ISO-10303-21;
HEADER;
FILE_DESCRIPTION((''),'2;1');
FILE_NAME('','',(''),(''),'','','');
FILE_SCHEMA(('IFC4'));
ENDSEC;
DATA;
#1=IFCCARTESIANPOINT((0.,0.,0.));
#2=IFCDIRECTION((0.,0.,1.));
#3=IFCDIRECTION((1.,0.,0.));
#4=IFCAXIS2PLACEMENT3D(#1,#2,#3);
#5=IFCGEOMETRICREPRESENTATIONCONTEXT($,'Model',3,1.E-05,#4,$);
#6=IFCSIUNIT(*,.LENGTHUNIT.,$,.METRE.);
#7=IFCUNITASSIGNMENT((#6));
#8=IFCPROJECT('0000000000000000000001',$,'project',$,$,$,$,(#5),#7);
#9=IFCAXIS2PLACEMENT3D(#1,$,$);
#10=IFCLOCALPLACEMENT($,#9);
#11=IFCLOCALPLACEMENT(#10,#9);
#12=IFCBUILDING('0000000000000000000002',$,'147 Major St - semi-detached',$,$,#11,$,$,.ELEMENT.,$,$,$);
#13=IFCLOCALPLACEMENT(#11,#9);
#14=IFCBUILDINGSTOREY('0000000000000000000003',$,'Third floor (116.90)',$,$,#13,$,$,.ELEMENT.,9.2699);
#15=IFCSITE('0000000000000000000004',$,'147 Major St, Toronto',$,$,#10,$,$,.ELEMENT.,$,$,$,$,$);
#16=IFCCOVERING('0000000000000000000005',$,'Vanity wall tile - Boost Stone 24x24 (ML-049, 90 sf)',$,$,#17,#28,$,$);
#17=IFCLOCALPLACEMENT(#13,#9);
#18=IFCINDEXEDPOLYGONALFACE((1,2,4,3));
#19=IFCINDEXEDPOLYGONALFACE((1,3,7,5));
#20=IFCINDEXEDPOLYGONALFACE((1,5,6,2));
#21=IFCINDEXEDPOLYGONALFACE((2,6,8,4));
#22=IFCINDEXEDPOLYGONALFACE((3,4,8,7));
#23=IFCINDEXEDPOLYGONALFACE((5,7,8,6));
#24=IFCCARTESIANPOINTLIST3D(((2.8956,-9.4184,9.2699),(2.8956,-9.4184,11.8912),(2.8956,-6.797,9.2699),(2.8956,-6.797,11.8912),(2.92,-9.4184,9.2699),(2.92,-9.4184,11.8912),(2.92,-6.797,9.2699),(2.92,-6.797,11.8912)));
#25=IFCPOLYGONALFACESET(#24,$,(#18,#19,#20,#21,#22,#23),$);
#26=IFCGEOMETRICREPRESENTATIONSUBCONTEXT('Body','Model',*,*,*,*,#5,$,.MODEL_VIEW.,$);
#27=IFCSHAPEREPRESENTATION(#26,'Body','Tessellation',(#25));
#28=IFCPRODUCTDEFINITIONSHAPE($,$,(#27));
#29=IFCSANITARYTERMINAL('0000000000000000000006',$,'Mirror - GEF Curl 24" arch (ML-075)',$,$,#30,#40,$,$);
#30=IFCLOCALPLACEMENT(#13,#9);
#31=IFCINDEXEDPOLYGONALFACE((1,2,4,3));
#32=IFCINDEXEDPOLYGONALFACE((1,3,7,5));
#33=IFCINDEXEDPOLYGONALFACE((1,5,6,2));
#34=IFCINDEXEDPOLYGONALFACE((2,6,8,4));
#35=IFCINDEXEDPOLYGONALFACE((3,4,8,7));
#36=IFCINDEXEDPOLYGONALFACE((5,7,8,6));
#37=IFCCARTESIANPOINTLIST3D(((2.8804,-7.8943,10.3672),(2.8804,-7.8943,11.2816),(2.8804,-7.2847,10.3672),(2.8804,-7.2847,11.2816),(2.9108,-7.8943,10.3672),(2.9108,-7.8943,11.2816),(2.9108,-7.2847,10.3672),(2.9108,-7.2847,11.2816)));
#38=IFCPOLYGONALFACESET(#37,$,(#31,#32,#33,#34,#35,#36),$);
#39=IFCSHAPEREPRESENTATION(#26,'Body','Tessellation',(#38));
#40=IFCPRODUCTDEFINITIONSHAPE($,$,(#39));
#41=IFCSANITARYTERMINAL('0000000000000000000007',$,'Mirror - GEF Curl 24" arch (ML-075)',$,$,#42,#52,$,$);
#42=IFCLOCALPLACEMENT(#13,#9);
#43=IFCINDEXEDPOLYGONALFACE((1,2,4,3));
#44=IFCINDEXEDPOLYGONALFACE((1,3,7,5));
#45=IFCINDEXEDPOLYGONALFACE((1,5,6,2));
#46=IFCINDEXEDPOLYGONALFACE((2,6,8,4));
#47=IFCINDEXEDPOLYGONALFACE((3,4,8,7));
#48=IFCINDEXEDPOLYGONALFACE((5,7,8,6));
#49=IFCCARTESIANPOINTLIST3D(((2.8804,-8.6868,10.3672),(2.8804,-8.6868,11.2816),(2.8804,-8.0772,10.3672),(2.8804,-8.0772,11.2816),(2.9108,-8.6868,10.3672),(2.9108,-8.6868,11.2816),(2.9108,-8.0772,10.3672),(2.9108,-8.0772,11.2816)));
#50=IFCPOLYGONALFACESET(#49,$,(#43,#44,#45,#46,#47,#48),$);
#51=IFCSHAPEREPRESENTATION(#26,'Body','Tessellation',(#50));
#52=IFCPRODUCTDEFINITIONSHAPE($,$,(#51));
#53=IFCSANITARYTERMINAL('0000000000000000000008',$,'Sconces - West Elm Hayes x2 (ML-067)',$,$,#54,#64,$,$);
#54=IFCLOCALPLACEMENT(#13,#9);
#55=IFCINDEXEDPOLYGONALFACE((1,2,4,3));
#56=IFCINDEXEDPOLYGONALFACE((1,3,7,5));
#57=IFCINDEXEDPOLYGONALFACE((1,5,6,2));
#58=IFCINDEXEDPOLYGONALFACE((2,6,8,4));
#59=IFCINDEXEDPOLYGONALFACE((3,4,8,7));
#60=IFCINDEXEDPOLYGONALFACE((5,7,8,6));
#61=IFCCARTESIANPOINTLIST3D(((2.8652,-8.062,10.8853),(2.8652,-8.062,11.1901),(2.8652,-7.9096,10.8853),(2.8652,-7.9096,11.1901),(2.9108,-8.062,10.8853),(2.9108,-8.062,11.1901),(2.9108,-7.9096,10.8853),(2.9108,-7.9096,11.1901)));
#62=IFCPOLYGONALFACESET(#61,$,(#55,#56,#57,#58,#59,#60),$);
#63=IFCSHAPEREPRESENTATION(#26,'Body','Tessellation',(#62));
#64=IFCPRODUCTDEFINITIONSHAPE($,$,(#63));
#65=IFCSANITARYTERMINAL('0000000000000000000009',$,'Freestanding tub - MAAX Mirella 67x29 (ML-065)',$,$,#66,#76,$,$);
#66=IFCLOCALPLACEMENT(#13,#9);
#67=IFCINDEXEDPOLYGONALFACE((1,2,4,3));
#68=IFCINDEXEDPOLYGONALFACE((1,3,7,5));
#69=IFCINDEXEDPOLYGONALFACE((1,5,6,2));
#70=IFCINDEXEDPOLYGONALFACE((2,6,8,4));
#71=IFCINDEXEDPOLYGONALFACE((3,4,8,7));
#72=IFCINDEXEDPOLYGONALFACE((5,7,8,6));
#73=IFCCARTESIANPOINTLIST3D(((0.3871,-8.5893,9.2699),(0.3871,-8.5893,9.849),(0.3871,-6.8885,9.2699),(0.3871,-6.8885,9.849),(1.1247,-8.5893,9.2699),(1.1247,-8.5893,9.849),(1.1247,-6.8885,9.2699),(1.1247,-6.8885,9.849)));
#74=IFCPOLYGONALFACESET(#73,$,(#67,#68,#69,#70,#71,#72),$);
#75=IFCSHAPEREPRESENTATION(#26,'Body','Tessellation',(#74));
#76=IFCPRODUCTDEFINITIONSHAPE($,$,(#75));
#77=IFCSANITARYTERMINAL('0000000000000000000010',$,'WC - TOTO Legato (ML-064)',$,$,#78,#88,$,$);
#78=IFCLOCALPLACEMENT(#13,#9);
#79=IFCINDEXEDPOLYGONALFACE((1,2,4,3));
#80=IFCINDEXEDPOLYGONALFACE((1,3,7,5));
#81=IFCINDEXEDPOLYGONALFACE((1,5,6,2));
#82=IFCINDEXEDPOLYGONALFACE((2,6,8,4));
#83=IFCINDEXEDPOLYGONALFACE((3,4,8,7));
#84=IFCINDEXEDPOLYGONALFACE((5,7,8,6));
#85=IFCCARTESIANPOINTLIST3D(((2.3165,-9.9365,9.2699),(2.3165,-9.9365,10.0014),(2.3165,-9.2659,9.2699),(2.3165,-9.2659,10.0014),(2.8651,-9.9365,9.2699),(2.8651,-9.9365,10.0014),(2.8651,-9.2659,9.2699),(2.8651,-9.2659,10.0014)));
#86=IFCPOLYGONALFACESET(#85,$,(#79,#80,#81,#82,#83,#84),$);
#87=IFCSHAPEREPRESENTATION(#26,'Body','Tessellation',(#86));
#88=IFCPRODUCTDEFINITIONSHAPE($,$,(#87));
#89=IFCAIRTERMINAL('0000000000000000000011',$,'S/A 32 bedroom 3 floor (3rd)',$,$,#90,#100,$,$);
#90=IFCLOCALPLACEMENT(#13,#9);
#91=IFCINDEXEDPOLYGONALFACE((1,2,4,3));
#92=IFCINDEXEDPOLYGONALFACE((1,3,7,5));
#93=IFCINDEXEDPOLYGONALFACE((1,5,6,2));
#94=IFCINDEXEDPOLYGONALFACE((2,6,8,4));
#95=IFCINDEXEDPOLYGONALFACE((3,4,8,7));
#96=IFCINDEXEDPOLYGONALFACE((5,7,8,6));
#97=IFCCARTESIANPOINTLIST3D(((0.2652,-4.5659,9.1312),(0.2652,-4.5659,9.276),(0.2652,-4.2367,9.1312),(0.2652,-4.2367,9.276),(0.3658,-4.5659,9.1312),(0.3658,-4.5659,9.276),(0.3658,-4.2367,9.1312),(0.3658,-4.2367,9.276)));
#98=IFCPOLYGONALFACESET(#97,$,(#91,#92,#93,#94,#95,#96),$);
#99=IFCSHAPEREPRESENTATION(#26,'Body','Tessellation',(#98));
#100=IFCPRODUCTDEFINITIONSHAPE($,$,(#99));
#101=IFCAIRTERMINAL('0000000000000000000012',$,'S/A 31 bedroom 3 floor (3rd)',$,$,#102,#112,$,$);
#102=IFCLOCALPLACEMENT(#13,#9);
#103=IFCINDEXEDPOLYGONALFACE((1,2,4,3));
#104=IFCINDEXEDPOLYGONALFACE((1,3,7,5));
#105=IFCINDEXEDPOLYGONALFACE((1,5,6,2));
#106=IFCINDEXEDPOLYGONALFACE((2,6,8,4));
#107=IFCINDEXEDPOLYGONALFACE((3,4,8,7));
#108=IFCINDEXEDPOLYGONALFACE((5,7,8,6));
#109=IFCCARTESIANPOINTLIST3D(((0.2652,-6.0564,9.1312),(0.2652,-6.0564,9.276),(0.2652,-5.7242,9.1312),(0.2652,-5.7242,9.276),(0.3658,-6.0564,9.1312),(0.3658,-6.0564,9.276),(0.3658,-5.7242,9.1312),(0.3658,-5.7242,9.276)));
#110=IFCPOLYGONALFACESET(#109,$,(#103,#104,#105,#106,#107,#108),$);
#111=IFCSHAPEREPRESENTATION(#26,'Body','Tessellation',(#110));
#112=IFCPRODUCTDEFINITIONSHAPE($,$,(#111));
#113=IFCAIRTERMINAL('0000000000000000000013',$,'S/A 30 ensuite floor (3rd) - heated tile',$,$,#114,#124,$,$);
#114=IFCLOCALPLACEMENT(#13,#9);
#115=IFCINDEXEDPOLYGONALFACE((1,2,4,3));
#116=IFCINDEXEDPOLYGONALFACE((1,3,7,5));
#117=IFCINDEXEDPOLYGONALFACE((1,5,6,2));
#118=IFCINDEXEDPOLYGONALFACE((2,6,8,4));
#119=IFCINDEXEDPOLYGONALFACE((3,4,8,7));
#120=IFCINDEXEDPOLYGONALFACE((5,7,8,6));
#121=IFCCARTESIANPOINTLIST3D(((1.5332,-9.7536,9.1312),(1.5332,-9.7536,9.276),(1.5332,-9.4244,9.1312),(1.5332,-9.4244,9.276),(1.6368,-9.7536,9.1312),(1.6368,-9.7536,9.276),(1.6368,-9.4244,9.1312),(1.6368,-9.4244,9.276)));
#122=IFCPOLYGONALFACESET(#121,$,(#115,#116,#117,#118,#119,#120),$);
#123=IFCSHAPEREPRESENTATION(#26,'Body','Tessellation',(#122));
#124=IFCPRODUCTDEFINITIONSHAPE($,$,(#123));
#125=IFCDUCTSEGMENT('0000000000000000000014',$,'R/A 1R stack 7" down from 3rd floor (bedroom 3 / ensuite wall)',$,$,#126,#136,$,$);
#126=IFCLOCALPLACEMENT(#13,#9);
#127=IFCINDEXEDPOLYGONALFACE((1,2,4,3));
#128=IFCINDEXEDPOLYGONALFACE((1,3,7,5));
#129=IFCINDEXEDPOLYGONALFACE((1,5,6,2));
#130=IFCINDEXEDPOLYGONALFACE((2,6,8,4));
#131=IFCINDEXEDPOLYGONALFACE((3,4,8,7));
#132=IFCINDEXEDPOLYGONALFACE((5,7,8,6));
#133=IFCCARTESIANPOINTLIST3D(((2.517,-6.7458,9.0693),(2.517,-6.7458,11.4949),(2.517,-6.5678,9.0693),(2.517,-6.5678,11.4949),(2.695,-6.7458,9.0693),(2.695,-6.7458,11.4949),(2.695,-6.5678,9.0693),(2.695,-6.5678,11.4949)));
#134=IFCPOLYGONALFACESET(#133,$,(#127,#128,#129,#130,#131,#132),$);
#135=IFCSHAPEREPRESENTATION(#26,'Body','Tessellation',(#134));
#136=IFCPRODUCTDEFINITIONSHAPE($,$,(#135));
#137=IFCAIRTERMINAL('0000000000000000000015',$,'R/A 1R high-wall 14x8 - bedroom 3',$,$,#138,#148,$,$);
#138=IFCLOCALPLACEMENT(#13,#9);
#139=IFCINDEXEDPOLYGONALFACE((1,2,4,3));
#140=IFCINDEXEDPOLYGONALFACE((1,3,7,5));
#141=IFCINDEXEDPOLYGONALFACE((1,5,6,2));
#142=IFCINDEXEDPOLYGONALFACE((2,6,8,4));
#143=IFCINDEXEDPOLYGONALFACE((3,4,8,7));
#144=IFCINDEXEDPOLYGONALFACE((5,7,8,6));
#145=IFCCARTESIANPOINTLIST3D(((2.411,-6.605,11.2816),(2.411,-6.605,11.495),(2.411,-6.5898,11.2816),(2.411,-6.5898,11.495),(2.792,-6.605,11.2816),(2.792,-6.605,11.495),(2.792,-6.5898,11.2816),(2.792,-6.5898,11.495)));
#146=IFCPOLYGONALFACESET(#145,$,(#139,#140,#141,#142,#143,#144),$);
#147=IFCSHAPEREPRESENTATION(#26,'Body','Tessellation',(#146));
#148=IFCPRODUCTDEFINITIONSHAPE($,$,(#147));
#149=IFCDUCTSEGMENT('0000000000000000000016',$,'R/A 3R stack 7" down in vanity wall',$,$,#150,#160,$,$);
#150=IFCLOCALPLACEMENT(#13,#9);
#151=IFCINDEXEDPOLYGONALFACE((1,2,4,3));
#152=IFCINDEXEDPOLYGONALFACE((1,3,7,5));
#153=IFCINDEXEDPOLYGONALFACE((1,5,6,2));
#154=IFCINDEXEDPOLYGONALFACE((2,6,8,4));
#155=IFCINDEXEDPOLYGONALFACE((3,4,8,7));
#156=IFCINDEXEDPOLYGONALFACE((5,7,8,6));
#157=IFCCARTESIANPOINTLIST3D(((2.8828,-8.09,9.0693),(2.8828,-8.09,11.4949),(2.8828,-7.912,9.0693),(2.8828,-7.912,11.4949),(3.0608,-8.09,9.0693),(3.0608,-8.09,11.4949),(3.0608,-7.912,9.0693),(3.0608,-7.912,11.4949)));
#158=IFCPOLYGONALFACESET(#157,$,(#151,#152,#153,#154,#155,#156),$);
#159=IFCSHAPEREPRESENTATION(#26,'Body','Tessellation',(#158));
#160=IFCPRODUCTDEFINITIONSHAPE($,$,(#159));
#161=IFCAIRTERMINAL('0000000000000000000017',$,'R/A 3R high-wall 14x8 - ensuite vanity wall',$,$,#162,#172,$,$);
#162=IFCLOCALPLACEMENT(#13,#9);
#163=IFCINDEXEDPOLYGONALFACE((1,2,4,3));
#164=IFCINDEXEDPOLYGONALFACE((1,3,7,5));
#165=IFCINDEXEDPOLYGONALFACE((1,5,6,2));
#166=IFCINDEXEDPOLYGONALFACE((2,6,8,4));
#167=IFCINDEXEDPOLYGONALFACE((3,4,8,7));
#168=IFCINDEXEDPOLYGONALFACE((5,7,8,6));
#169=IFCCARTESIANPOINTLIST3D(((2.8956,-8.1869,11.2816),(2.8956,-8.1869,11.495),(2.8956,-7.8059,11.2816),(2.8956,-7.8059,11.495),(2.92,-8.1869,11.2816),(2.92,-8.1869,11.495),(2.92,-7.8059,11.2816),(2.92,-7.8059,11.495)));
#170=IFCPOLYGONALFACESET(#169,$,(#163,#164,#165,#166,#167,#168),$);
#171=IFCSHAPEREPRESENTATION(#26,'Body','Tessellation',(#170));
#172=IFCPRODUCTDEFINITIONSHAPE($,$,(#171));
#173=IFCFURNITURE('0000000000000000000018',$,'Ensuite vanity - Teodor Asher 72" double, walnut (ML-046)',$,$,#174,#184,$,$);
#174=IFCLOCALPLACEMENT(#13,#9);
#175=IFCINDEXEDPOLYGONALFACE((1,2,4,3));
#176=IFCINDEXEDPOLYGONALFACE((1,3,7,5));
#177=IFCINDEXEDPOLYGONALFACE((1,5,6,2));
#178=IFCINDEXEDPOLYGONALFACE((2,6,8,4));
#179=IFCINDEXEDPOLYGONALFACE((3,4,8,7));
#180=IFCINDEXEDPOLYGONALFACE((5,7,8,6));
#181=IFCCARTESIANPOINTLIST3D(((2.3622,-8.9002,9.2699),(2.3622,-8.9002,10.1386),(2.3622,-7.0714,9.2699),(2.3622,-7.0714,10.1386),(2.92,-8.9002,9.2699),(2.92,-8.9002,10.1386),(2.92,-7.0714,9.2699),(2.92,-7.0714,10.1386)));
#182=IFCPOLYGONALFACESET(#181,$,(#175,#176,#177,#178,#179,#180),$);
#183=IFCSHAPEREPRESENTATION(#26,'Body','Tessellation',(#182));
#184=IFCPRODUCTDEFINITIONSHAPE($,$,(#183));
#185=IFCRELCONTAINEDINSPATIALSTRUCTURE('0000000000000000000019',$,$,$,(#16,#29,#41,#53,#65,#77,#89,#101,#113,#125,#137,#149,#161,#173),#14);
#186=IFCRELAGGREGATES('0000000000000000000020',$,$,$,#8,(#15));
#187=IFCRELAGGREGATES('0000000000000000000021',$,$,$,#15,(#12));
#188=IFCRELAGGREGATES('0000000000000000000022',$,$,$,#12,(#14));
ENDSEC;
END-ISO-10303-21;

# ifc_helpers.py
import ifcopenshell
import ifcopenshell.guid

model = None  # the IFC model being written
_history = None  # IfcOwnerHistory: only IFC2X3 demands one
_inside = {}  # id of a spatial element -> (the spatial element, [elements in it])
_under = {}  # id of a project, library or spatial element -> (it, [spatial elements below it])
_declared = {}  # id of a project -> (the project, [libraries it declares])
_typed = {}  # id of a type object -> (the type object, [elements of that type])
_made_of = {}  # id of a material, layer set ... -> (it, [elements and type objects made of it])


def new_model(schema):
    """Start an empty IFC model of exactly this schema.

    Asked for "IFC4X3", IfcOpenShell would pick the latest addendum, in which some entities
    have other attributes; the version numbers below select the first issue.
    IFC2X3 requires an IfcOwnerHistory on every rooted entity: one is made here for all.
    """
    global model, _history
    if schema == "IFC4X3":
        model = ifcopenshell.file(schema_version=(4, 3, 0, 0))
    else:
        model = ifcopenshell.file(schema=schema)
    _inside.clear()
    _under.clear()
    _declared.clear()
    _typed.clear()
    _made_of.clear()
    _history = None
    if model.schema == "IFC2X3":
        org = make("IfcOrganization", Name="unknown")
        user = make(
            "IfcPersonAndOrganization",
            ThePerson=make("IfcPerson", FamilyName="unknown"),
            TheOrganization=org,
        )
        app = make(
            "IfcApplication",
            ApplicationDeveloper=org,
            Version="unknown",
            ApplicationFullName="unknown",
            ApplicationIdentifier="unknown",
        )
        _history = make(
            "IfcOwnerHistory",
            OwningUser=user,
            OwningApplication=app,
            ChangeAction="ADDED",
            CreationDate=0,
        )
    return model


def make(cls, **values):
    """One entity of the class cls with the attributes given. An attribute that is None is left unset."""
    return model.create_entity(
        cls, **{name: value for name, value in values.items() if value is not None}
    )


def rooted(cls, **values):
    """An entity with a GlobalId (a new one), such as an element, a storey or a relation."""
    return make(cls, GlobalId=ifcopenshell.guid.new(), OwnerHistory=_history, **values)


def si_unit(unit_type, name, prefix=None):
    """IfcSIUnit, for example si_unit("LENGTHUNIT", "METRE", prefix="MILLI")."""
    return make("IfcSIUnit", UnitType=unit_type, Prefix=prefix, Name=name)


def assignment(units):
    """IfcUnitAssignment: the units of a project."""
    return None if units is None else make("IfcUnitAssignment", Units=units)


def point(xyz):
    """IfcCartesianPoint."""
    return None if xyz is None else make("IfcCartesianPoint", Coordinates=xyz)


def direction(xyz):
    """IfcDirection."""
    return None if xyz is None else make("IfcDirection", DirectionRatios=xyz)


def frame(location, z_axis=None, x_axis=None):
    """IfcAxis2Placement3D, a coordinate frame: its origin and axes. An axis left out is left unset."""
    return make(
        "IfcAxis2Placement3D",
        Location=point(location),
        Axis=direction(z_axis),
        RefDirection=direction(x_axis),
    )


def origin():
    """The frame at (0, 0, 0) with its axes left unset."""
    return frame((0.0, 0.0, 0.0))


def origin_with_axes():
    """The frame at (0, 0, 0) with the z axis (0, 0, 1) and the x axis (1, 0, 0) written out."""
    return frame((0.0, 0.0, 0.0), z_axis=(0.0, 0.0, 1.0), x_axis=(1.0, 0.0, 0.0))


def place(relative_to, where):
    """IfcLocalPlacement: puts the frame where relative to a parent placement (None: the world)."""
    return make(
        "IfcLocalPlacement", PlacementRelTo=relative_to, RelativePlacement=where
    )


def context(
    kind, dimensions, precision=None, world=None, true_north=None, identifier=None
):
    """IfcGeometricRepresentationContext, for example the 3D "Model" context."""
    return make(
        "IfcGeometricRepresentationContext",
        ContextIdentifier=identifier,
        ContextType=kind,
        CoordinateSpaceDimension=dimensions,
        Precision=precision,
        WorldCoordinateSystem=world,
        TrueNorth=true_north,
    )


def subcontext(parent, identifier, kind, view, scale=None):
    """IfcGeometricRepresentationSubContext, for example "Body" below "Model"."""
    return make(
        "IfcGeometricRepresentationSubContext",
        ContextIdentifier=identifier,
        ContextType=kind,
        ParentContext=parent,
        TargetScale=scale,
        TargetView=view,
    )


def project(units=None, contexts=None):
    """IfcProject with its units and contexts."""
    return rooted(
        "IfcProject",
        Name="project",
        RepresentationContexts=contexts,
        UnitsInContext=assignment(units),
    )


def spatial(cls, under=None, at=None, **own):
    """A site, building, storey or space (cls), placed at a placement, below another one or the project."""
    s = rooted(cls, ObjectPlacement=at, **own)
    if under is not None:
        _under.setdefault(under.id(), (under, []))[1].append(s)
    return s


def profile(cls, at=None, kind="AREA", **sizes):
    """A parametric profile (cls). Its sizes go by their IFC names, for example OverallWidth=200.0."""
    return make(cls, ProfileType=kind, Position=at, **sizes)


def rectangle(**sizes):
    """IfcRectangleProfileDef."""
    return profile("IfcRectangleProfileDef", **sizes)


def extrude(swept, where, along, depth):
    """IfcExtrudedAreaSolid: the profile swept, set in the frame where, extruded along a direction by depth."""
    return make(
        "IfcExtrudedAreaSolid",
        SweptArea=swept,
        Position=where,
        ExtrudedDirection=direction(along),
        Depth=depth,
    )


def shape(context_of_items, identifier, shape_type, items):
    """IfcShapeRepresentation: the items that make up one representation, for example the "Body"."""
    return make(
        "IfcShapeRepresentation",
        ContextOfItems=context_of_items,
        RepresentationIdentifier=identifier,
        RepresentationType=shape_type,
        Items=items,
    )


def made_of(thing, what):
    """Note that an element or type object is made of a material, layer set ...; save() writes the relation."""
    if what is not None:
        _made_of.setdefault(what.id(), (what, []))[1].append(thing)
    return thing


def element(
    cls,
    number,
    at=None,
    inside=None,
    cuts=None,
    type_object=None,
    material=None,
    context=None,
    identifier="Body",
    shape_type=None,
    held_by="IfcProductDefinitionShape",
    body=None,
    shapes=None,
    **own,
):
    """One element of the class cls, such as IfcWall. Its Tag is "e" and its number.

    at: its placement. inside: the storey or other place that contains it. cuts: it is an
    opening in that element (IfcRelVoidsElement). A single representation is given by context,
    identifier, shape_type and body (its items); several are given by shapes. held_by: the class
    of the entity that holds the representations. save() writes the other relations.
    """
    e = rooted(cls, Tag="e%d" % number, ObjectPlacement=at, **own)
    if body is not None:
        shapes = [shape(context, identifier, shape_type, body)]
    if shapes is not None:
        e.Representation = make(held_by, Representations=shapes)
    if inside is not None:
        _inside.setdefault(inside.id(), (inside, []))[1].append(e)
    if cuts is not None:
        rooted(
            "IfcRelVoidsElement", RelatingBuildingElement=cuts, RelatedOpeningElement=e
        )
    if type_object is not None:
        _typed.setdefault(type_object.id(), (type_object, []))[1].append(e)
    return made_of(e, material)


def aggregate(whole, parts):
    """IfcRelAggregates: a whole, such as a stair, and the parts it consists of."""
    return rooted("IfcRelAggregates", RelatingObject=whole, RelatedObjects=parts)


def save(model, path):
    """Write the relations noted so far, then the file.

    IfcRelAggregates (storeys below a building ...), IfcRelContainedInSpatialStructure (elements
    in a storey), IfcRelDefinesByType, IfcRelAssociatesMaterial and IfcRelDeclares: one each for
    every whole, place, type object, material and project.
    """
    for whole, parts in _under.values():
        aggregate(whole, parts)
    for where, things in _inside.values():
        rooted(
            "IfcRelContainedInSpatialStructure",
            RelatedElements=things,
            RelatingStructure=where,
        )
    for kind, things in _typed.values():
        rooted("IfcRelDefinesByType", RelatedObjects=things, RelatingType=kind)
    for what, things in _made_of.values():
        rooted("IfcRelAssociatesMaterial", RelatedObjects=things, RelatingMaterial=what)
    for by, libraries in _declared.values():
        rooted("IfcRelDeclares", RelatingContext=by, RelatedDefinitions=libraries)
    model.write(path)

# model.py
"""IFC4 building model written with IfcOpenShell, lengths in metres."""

from ifc_helpers import new_model, si_unit, frame, origin, origin_with_axes, place, context, subcontext, project, spatial, rectangle, extrude, element, save


model = new_model("IFC4")

# Units and contexts
model_context = context("Model", 3, precision=1e-05, world=origin_with_axes())
body_context = subcontext(model_context, "Body", "Model", "MODEL_VIEW")
ifc_project = project(units=[si_unit("LENGTHUNIT", "METRE")], contexts=[model_context])

# Site, building, storey
site_placement = place(None, origin())
site = spatial("IfcSite", under=ifc_project, at=site_placement, Name="147 Major St, Toronto", CompositionType="ELEMENT")
building_placement = place(site_placement, origin())
building = spatial("IfcBuilding", under=site, at=building_placement, Name="147 Major St - semi-detached", CompositionType="ELEMENT")
storey_placement = place(building_placement, origin())
storey = spatial("IfcBuildingStorey", under=building, at=storey_placement, Name="Third floor (116.90)", CompositionType="ELEMENT", Elevation=9.2699)

# Covering
covering_1_placement = place(storey_placement, frame((2.9078, -8.1077, 9.2699)))
element("IfcCovering", 1, at=covering_1_placement, inside=storey, Name="Vanity wall tile - Boost Stone 24x24 (ML-049, 90 sf)", context=body_context, shape_type="SweptSolid", body=[
    extrude(rectangle(XDim=0.0244, YDim=2.6213), origin_with_axes(), (0.0, 0.0, 1.0), 2.6213),
])

# Sanitary terminals
for number, where, name in (
    (2, (2.8956, -7.5895, 10.3672), "Mirror - GEF Curl 24\" arch (ML-075)"),
    (3, (2.8956, -8.382, 10.3672), "Mirror - GEF Curl 24\" arch (ML-075)"),
):
    element("IfcSanitaryTerminal", number, at=place(storey_placement, frame(where)), inside=storey, Name=name, context=body_context, shape_type="SweptSolid", body=[
        extrude(rectangle(XDim=0.0305, YDim=0.6096), origin_with_axes(), (0.0, 0.0, 1.0), 0.9144),
    ])
sanitary_terminal_1_placement = place(storey_placement, frame((2.888, -7.9858, 10.8853)))
element("IfcSanitaryTerminal", 4, at=sanitary_terminal_1_placement, inside=storey, Name="Sconces - West Elm Hayes x2 (ML-067)", context=body_context, shape_type="SweptSolid", body=[
    extrude(rectangle(XDim=0.0457, YDim=0.1524), origin_with_axes(), (0.0, 0.0, 1.0), 0.3048),
])
sanitary_terminal_2_placement = place(storey_placement, frame((0.7559, -7.7389, 9.2699)))
element("IfcSanitaryTerminal", 5, at=sanitary_terminal_2_placement, inside=storey, Name="Freestanding tub - MAAX Mirella 67x29 (ML-065)", context=body_context, shape_type="SweptSolid", body=[
    extrude(rectangle(XDim=0.7376, YDim=1.7008), origin_with_axes(), (0.0, 0.0, 1.0), 0.5791),
])
sanitary_terminal_3_placement = place(storey_placement, frame((2.5908, -9.6012, 9.2699)))
element("IfcSanitaryTerminal", 6, at=sanitary_terminal_3_placement, inside=storey, Name="WC - TOTO Legato (ML-064)", context=body_context, shape_type="SweptSolid", body=[
    extrude(rectangle(XDim=0.5486, YDim=0.6706), origin_with_axes(), (0.0, 0.0, 1.0), 0.7315),
])

# Air terminals
air_terminal_1_placement = place(storey_placement, frame((0.3155, -4.4013, 9.1312)))
element("IfcAirTerminal", 7, at=air_terminal_1_placement, inside=storey, Name="S/A 32 bedroom 3 floor (3rd)", context=body_context, shape_type="SweptSolid", body=[
    extrude(rectangle(XDim=0.1006, YDim=0.3292), origin_with_axes(), (0.0, 0.0, 1.0), 0.1448),
])
air_terminal_2_placement = place(storey_placement, frame((0.3155, -5.8903, 9.1312)))
element("IfcAirTerminal", 8, at=air_terminal_2_placement, inside=storey, Name="S/A 31 bedroom 3 floor (3rd)", context=body_context, shape_type="SweptSolid", body=[
    extrude(rectangle(XDim=0.1006, YDim=0.3322), origin_with_axes(), (0.0, 0.0, 1.0), 0.1448),
])
air_terminal_3_placement = place(storey_placement, frame((1.585, -9.589, 9.1312)))
element("IfcAirTerminal", 9, at=air_terminal_3_placement, inside=storey, Name="S/A 30 ensuite floor (3rd) - heated tile", context=body_context, shape_type="SweptSolid", body=[
    extrude(rectangle(XDim=0.1036, YDim=0.3292), origin_with_axes(), (0.0, 0.0, 1.0), 0.1448),
])

# Duct segment
duct_segment_1_placement = place(storey_placement, frame((2.606, -6.6568, 9.0693)))
element("IfcDuctSegment", 10, at=duct_segment_1_placement, inside=storey, Name="R/A 1R stack 7\" down from 3rd floor (bedroom 3 / ensuite wall)", context=body_context, shape_type="SweptSolid", body=[
    extrude(rectangle(XDim=0.178, YDim=0.178), origin_with_axes(), (0.0, 0.0, 1.0), 2.4256),
])

# Air terminal
air_terminal_4_placement = place(storey_placement, frame((2.6015, -6.5974, 11.2816)))
element("IfcAirTerminal", 11, at=air_terminal_4_placement, inside=storey, Name="R/A 1R high-wall 14x8 - bedroom 3", context=body_context, shape_type="SweptSolid", body=[
    extrude(rectangle(XDim=0.381, YDim=0.0152), origin_with_axes(), (0.0, 0.0, 1.0), 0.2134),
])

# Duct segment
duct_segment_2_placement = place(storey_placement, frame((2.9718, -8.001, 9.0693)))
element("IfcDuctSegment", 12, at=duct_segment_2_placement, inside=storey, Name="R/A 3R stack 7\" down in vanity wall", context=body_context, shape_type="SweptSolid", body=[
    extrude(rectangle(XDim=0.178, YDim=0.178), origin_with_axes(), (0.0, 0.0, 1.0), 2.4256),
])

# Air terminal
air_terminal_5_placement = place(storey_placement, frame((2.9078, -7.9964, 11.2816)))
element("IfcAirTerminal", 13, at=air_terminal_5_placement, inside=storey, Name="R/A 3R high-wall 14x8 - ensuite vanity wall", context=body_context, shape_type="SweptSolid", body=[
    extrude(rectangle(XDim=0.0244, YDim=0.381), origin_with_axes(), (0.0, 0.0, 1.0), 0.2134),
])

# Furniture
furniture_placement = place(storey_placement, frame((2.6411, -7.9858, 9.2699)))
element("IfcFurniture", 14, at=furniture_placement, inside=storey, Name="Ensuite vanity - Teodor Asher 72\" double, walnut (ML-046)", context=body_context, shape_type="SweptSolid", body=[
    extrude(rectangle(XDim=0.5578, YDim=1.8288), origin_with_axes(), (0.0, 0.0, 1.0), 0.8687),
])

save(model, "model.ifc")
